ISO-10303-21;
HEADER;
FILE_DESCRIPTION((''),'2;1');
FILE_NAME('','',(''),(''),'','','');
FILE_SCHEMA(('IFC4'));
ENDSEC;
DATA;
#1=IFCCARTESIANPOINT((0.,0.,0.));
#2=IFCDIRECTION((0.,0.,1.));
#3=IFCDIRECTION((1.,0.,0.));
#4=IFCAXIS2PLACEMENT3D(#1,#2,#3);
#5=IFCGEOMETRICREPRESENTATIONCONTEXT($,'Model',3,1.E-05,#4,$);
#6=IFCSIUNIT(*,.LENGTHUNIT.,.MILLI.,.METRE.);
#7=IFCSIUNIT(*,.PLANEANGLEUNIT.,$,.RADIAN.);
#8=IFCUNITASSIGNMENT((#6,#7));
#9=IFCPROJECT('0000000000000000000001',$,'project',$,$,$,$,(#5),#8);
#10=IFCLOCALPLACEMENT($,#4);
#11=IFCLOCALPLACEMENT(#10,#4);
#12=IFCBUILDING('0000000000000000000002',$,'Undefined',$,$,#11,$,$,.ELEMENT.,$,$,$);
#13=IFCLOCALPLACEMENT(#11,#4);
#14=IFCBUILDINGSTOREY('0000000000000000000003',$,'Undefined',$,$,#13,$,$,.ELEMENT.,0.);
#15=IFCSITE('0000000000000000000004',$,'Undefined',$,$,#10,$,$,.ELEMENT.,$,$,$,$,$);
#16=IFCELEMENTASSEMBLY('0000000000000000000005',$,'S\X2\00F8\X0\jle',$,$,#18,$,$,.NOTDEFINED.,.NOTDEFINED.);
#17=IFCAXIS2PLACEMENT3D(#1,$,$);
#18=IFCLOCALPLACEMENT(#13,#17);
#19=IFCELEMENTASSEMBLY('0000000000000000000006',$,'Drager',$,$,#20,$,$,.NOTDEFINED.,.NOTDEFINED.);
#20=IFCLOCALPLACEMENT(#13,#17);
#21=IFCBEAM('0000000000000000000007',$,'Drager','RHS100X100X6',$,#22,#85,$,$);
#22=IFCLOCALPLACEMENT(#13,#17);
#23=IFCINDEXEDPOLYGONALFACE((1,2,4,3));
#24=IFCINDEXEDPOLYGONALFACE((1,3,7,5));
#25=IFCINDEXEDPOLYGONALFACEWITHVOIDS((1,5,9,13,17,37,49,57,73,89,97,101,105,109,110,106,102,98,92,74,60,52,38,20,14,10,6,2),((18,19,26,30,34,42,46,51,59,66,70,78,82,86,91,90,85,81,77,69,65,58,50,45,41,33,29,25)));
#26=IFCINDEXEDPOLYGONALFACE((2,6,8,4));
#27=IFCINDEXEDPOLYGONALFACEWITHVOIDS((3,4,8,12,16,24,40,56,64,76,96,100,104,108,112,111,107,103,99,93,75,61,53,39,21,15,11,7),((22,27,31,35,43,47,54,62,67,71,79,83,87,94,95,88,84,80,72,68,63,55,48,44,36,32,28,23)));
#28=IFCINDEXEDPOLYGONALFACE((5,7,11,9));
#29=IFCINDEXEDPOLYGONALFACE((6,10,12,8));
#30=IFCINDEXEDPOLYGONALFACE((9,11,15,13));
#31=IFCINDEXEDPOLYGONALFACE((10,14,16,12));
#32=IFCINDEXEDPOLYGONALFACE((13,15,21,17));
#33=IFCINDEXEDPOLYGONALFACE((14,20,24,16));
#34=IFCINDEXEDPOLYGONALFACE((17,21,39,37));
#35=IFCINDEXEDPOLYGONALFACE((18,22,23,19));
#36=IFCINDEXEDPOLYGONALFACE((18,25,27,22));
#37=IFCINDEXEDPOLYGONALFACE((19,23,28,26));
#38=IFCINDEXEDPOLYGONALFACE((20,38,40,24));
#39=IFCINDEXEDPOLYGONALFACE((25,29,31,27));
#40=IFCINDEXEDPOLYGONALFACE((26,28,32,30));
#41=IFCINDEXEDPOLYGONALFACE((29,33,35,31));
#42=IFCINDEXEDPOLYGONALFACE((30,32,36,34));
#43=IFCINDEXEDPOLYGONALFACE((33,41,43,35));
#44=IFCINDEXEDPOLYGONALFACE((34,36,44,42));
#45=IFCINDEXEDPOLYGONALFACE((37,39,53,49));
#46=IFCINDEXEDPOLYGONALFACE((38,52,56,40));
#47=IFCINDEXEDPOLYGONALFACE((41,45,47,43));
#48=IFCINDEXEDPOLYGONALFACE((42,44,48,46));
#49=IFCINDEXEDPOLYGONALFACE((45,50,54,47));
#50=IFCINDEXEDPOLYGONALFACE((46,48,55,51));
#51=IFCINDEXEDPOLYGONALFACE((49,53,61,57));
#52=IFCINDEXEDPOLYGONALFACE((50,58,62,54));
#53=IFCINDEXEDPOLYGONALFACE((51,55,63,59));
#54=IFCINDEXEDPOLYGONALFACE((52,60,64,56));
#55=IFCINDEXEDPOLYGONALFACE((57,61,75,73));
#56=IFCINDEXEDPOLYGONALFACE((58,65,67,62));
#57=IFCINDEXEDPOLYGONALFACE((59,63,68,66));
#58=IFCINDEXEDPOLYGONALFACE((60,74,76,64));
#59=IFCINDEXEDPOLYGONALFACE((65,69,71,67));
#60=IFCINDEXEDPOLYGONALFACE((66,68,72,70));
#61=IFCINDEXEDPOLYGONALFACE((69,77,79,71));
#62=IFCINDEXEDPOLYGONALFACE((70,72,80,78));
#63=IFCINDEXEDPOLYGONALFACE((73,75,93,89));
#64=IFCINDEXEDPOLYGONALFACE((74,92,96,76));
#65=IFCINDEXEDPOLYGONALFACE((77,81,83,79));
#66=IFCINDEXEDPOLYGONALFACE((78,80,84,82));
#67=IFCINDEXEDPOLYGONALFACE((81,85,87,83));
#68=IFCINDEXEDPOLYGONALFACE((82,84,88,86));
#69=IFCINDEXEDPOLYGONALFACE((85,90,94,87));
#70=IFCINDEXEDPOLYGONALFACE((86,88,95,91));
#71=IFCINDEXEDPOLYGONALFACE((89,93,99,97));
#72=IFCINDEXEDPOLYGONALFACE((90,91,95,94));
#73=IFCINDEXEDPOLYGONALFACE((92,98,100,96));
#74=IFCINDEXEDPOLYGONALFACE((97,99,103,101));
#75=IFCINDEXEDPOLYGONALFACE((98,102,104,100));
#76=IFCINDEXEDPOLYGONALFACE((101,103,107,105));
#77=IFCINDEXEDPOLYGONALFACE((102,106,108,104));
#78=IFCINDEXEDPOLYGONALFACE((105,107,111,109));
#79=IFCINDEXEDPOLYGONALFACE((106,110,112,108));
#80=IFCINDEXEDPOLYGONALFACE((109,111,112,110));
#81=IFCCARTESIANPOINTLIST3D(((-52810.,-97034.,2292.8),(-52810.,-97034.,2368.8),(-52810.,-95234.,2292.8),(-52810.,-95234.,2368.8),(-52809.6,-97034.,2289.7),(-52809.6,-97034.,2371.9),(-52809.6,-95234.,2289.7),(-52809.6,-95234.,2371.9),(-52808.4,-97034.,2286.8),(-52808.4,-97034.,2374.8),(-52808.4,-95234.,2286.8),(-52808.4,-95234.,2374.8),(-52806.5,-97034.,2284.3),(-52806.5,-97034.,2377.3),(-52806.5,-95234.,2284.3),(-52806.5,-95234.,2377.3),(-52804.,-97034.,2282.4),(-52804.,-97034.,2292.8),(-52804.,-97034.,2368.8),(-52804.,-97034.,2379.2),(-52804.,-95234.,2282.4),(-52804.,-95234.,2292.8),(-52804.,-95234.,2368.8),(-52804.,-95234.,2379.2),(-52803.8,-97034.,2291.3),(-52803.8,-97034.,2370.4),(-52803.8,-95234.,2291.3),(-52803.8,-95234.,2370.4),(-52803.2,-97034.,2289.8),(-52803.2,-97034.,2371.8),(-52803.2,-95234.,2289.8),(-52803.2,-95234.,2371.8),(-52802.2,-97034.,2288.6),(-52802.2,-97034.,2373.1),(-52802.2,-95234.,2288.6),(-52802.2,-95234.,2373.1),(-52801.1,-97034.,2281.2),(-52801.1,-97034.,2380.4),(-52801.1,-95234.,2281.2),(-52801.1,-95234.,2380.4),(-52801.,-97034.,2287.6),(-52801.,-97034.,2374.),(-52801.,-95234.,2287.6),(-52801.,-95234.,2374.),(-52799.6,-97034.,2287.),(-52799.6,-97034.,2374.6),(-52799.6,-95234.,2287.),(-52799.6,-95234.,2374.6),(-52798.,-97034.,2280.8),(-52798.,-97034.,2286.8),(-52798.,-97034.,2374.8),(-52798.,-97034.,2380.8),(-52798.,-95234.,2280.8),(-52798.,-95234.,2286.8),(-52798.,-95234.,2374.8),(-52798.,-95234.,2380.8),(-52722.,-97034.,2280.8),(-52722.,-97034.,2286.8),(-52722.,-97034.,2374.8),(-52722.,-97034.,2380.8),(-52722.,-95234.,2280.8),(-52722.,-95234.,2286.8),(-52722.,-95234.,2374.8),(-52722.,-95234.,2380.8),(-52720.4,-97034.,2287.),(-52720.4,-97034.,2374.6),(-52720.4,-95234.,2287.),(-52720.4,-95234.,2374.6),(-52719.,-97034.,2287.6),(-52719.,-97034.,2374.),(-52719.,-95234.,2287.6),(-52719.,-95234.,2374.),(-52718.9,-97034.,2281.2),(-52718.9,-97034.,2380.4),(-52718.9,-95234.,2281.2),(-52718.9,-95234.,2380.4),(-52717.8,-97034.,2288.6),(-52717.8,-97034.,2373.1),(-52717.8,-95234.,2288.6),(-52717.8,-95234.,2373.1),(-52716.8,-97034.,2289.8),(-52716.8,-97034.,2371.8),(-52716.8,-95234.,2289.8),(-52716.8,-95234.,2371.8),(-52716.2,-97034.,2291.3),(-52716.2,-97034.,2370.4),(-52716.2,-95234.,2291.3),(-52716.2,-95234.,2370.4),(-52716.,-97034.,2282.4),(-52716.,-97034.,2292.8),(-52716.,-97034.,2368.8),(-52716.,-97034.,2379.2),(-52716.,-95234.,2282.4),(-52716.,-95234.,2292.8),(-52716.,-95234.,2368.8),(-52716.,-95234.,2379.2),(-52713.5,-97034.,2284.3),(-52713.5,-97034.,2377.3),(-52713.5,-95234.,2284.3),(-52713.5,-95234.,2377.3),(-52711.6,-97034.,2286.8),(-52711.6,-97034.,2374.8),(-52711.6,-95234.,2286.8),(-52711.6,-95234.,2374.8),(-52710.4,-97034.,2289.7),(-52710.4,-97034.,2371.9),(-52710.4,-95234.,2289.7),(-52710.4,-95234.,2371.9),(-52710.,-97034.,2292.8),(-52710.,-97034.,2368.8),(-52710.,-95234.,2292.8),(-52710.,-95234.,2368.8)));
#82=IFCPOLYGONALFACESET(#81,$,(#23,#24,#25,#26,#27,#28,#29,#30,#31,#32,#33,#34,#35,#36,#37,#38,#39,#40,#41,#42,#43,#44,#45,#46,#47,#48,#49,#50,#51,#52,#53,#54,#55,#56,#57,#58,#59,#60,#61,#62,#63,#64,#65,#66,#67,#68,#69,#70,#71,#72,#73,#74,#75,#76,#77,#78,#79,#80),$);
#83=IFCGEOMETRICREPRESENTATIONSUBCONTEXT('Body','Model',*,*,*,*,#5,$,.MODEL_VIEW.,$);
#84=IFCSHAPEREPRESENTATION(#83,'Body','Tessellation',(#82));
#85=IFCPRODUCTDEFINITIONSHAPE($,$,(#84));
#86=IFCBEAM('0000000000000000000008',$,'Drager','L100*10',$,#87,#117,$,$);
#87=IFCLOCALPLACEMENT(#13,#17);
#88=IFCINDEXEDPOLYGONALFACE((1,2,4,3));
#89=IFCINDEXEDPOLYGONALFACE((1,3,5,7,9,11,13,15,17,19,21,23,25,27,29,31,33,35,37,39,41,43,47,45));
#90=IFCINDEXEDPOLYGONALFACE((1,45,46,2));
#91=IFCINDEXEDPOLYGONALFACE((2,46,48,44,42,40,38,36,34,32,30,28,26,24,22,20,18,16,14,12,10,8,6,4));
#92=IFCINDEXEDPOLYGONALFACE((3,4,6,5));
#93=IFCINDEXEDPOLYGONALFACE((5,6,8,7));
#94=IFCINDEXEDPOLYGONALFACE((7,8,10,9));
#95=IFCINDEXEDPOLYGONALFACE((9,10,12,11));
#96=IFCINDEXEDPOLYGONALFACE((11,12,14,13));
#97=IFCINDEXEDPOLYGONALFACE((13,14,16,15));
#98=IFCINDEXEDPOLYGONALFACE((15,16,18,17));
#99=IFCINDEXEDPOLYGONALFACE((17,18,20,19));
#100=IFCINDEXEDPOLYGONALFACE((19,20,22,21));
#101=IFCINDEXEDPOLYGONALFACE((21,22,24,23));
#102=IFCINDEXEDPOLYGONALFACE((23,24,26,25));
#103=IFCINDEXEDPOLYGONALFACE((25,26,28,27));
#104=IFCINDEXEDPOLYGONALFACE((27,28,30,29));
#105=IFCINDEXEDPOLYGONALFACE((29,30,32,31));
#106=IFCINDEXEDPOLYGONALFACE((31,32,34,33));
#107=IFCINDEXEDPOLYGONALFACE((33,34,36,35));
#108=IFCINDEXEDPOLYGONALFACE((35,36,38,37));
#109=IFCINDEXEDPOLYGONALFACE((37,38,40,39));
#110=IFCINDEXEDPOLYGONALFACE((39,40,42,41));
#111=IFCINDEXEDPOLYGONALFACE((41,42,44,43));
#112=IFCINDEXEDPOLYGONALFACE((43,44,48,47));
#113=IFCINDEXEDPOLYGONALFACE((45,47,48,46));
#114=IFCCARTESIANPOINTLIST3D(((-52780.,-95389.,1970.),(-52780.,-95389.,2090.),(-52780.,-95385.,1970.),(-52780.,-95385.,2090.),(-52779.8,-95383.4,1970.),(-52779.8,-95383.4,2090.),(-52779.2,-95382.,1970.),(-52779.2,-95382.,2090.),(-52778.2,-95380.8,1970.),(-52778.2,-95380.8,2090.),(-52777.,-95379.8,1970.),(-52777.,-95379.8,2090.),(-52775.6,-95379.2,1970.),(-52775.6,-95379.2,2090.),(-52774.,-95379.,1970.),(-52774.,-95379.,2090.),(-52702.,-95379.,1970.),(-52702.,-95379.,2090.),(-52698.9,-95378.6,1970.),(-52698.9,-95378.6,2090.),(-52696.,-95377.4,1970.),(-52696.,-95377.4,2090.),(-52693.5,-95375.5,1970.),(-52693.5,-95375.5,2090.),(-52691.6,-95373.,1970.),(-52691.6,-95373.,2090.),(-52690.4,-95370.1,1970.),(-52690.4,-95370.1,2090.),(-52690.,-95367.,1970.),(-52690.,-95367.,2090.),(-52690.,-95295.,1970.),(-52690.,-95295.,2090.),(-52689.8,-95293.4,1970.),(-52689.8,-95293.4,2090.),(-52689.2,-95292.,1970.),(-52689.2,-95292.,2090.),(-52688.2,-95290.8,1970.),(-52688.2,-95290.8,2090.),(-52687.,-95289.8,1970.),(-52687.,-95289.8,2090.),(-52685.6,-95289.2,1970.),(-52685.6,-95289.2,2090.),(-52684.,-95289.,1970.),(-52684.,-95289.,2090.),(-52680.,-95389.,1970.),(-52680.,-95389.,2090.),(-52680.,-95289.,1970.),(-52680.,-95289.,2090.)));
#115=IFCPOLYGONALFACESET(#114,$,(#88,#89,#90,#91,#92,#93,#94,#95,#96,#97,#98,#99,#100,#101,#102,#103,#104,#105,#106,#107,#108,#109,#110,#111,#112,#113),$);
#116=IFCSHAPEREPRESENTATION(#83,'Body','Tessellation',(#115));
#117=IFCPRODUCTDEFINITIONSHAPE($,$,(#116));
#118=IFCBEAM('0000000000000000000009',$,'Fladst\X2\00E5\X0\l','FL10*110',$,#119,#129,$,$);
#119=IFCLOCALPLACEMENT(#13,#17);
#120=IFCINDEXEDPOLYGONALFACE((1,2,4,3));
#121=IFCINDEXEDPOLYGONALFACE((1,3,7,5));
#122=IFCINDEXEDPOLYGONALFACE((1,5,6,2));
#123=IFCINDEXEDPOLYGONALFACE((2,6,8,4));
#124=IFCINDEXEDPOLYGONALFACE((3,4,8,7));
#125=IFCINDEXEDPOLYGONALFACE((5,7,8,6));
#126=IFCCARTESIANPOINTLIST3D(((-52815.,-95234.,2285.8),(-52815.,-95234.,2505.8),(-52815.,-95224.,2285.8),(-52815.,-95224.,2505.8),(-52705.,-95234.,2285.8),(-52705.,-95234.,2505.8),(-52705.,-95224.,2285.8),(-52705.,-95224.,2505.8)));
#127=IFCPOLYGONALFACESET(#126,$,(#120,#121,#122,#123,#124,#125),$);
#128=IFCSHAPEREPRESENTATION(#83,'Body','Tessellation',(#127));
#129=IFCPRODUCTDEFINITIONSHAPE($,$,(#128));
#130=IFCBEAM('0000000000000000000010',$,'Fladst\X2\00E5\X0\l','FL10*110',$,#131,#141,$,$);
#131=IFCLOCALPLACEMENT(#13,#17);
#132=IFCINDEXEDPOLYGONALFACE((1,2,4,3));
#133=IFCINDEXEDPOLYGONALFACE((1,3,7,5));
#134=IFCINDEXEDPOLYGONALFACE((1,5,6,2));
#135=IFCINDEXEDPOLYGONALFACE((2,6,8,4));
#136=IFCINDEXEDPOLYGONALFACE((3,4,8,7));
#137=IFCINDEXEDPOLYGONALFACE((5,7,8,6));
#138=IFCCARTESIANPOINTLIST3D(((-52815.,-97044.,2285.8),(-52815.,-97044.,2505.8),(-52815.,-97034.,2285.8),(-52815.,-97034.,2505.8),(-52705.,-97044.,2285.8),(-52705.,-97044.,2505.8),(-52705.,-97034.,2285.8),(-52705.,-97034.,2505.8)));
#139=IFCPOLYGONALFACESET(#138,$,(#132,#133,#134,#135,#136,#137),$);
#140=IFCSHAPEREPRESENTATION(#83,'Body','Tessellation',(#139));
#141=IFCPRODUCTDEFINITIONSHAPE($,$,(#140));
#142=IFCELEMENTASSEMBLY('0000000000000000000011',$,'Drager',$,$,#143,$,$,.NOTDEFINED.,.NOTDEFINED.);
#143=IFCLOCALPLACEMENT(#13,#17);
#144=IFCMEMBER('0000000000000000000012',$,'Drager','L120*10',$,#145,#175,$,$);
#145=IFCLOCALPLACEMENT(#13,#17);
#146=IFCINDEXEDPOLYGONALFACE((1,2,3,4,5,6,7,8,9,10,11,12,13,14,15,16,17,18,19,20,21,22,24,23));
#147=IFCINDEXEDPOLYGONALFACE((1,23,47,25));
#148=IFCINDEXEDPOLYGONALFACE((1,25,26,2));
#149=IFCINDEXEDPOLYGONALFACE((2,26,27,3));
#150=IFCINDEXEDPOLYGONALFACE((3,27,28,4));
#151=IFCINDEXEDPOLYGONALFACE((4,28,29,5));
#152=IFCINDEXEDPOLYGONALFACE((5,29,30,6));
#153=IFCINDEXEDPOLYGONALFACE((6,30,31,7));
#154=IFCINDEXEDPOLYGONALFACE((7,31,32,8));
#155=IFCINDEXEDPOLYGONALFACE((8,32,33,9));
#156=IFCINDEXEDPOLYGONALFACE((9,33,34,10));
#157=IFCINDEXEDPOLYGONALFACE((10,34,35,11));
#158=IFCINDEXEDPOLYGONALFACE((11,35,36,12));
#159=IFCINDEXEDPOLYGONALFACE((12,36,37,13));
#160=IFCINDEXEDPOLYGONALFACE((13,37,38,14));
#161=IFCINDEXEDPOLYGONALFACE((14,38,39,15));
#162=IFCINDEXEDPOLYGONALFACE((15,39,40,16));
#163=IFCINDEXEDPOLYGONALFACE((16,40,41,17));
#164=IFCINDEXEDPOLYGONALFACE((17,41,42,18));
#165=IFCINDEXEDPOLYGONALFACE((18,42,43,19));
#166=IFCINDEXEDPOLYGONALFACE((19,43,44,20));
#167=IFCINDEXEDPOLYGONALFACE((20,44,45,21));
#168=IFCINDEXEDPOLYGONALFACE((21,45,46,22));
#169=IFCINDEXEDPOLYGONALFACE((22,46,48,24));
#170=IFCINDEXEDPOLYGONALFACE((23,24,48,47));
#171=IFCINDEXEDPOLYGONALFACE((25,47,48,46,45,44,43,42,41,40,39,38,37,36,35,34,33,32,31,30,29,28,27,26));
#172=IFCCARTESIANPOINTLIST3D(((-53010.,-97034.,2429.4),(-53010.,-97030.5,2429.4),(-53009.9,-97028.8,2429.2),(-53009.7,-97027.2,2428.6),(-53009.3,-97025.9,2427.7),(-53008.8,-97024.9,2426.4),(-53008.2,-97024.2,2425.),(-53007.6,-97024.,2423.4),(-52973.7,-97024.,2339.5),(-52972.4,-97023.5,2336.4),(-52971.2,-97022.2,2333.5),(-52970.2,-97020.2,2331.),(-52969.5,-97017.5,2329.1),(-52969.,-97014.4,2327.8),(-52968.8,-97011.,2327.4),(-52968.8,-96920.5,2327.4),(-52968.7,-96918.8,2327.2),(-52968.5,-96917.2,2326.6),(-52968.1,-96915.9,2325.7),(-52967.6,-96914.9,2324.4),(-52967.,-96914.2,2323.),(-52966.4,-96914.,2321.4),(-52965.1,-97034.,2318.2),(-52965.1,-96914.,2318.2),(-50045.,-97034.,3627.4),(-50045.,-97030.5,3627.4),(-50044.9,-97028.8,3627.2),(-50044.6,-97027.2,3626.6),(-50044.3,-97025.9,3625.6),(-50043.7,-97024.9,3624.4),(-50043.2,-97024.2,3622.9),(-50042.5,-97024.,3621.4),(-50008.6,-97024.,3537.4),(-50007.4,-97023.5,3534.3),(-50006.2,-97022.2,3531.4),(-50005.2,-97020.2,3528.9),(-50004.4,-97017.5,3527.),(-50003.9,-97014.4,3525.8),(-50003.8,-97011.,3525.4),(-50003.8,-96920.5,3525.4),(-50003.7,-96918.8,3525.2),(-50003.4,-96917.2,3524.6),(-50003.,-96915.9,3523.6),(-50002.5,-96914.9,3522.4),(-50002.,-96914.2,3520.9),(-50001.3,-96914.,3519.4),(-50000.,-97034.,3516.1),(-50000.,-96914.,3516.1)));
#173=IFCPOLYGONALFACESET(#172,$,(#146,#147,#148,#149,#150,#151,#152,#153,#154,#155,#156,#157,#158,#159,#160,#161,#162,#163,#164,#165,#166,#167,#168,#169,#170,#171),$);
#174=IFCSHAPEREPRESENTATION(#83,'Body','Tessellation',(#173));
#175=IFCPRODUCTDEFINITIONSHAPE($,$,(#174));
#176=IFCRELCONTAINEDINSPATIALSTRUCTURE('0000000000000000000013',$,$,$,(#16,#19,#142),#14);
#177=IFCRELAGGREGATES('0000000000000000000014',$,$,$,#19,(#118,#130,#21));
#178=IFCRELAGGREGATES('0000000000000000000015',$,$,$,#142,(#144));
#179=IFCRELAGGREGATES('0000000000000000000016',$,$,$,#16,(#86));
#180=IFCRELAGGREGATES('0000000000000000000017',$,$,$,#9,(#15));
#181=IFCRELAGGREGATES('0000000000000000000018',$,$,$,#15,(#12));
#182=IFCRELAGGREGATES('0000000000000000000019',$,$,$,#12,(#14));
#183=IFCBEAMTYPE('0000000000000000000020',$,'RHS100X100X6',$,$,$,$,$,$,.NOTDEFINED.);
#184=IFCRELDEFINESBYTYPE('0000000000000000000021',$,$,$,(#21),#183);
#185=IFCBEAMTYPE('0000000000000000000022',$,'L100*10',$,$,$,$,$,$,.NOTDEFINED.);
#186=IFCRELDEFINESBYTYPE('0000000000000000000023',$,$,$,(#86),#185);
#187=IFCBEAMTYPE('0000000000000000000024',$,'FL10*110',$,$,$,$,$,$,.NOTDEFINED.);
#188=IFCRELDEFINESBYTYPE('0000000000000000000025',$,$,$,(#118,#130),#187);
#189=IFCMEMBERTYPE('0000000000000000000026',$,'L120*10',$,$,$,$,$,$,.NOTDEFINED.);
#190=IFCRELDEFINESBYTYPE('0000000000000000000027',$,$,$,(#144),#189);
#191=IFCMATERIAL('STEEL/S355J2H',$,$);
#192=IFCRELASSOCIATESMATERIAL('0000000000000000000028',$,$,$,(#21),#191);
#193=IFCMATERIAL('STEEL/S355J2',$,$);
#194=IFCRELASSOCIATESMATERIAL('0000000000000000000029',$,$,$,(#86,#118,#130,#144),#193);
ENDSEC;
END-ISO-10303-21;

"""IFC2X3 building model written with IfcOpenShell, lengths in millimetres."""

from ifc_helpers import new_model, si_unit, frame, origin_with_axes, origin_2d_with_axis, place, context, subcontext, project, spatial, rectangle, hollow_rectangle, l_section, extrude, clip, halfspace, material, type_object, element, aggregate, save


model = new_model("IFC2X3")

# Units and contexts
model_context = context("Model", 3, precision=1e-05, world=origin_with_axes())
body_context = subcontext(model_context, "Body", "Model", "MODEL_VIEW")
ifc_project = project(units=[si_unit("LENGTHUNIT", "METRE", prefix="MILLI"), si_unit("PLANEANGLEUNIT", "RADIAN")], contexts=[model_context])

# Site, building, storey
site_placement = place(None, origin_with_axes())
site = spatial("IfcSite", under=ifc_project, at=site_placement, Name="Undefined", CompositionType="ELEMENT")
building_placement = place(site_placement, origin_with_axes())
building = spatial("IfcBuilding", under=site, at=building_placement, Name="Undefined", CompositionType="ELEMENT")
storey_placement = place(building_placement, origin_with_axes())
storey = spatial("IfcBuildingStorey", under=building, at=storey_placement, Name="Undefined", CompositionType="ELEMENT", Elevation=0.0)

# Element assembly
ifc_material_1 = material(Name="STEEL/S355J2H")
assembly_1_placement = place(storey_placement, origin_with_axes())
assembly_1 = element("IfcElementAssembly", 1, at=assembly_1_placement, inside=storey, Name="Søjle", AssemblyPlace="NOTDEFINED", PredefinedType="NOTDEFINED")

# Element assembly, beam
beam_type_1 = type_object("IfcBeamType", Name="RHS100X100X6", PredefinedType="NOTDEFINED")
assembly_2_placement = place(storey_placement, origin_with_axes())
assembly_2 = element("IfcElementAssembly", 2, at=assembly_2_placement, inside=storey, Name="Drager", AssemblyPlace="NOTDEFINED", PredefinedType="NOTDEFINED")
beam_1_placement = place(assembly_2_placement, frame((-52760.0, -95234.0, 2330.8), z_axis=(1.0, 0.0, 0.0), x_axis=(0.0, -1.0, 0.0)))
beam_1 = element("IfcBeam", 3, at=beam_1_placement, type_object=beam_type_1, material=ifc_material_1, Name="Drager", Description="RHS100X100X6", context=body_context, shape_type="SweptSolid", body=[
    extrude(hollow_rectangle(XDim=100.0, YDim=100.0, WallThickness=6.0, InnerFilletRadius=6.0, OuterFilletRadius=12.0, at=origin_2d_with_axis()), frame((1800.0, 0.0, 0.0), z_axis=(-1.0, 0.0, 0.0), x_axis=(0.0, -1.0, 0.0)), (0.0, 0.0, 1.0), 1800.0),
])

# Beams
ifc_material_2 = material(Name="STEEL/S355J2")
beam_type_2 = type_object("IfcBeamType", Name="L100*10", PredefinedType="NOTDEFINED")
beam_2_placement = place(assembly_1_placement, frame((-52730.0, -95339.0, 2090.0), z_axis=(-1.0, 0.0, 0.0), x_axis=(0.0, 0.0, -1.0)))
beam_2 = element("IfcBeam", 4, at=beam_2_placement, type_object=beam_type_2, material=ifc_material_2, Name="Drager", Description="L100*10", context=body_context, shape_type="SweptSolid", body=[
    extrude(l_section(Depth=100.0, Width=100.0, Thickness=10.0, FilletRadius=12.0, EdgeRadius=6.0, at=origin_2d_with_axis()), frame((120.0, 0.0, 0.0), z_axis=(-1.0, 0.0, 0.0), x_axis=(0.0, -1.0, 0.0)), (0.0, 0.0, 1.0), 120.0),
])
beam_type_3 = type_object("IfcBeamType", Name="FL10*110", PredefinedType="NOTDEFINED")
beam_3_placement = place(assembly_2_placement, frame((-52760.0, -95229.0, 2285.8), z_axis=(-1.0, 0.0, 0.0), x_axis=(0.0, 0.0, 1.0)))
beam_3 = element("IfcBeam", 5, at=beam_3_placement, type_object=beam_type_3, material=ifc_material_2, Name="Fladstål", Description="FL10*110", context=body_context, shape_type="SweptSolid", body=[
    extrude(rectangle(XDim=10.0, YDim=110.0, at=origin_2d_with_axis()), frame((220.0, 0.0, 0.0), z_axis=(-1.0, 0.0, 0.0), x_axis=(0.0, -1.0, 0.0)), (0.0, 0.0, 1.0), 220.0),
])
beam_4_placement = place(assembly_2_placement, frame((-52760.0, -97039.0, 2285.8), z_axis=(-1.0, 0.0, 0.0), x_axis=(0.0, 0.0, 1.0)))
beam_4 = element("IfcBeam", 6, at=beam_4_placement, type_object=beam_type_3, material=ifc_material_2, Name="Fladstål", Description="FL10*110", context=body_context, shape_type="SweptSolid", body=[
    extrude(rectangle(XDim=10.0, YDim=110.0, at=origin_2d_with_axis()), frame((220.0, 0.0, 0.0), z_axis=(-1.0, 0.0, 0.0), x_axis=(0.0, -1.0, 0.0)), (0.0, 0.0, 1.0), 220.0),
])

# Element assembly, member
assembly_3_placement = place(storey_placement, origin_with_axes())
assembly_3 = element("IfcElementAssembly", 7, at=assembly_3_placement, inside=storey, Name="Drager", AssemblyPlace="NOTDEFINED", PredefinedType="NOTDEFINED")
member_type = type_object("IfcMemberType", Name="L120*10", PredefinedType="NOTDEFINED")
member_placement = place(assembly_3_placement, frame((-52987.5, -96974.0, 2373.8), z_axis=(0.0, 1.0, 0.0), x_axis=(0.927184, 0.0, 0.374606)))
member = element("IfcMember", 8, at=member_placement, type_object=member_type, material=ifc_material_2, Name="Drager", Description="L120*10", context=body_context, shape_type="Clipping", body=[
    clip(clip(extrude(l_section(Depth=120.0, Width=120.0, Thickness=10.0, FilletRadius=13.0, EdgeRadius=6.5, at=origin_2d_with_axis()), frame((3282.1, 0.0, 0.0), z_axis=(-1.0, 0.0, 0.0), x_axis=(0.0, -1.0, 0.0)), (0.0, 0.0, 1.0), 3366.3), halfspace(frame((3197.9, 0.0, -60.0), z_axis=(-1.0, 0.0, 0.0), x_axis=(0.0, 1.0, 0.0)), True)), halfspace(frame((0.0, 0.0, -60.0), z_axis=(1.0, 0.0, 0.0), x_axis=(0.0, -1.0, 0.0)), True)),
])

aggregate(assembly_2, [beam_3, beam_4, beam_1])

aggregate(assembly_3, [member])
aggregate(assembly_1, [beam_2])

save(model, "model.ifc")
